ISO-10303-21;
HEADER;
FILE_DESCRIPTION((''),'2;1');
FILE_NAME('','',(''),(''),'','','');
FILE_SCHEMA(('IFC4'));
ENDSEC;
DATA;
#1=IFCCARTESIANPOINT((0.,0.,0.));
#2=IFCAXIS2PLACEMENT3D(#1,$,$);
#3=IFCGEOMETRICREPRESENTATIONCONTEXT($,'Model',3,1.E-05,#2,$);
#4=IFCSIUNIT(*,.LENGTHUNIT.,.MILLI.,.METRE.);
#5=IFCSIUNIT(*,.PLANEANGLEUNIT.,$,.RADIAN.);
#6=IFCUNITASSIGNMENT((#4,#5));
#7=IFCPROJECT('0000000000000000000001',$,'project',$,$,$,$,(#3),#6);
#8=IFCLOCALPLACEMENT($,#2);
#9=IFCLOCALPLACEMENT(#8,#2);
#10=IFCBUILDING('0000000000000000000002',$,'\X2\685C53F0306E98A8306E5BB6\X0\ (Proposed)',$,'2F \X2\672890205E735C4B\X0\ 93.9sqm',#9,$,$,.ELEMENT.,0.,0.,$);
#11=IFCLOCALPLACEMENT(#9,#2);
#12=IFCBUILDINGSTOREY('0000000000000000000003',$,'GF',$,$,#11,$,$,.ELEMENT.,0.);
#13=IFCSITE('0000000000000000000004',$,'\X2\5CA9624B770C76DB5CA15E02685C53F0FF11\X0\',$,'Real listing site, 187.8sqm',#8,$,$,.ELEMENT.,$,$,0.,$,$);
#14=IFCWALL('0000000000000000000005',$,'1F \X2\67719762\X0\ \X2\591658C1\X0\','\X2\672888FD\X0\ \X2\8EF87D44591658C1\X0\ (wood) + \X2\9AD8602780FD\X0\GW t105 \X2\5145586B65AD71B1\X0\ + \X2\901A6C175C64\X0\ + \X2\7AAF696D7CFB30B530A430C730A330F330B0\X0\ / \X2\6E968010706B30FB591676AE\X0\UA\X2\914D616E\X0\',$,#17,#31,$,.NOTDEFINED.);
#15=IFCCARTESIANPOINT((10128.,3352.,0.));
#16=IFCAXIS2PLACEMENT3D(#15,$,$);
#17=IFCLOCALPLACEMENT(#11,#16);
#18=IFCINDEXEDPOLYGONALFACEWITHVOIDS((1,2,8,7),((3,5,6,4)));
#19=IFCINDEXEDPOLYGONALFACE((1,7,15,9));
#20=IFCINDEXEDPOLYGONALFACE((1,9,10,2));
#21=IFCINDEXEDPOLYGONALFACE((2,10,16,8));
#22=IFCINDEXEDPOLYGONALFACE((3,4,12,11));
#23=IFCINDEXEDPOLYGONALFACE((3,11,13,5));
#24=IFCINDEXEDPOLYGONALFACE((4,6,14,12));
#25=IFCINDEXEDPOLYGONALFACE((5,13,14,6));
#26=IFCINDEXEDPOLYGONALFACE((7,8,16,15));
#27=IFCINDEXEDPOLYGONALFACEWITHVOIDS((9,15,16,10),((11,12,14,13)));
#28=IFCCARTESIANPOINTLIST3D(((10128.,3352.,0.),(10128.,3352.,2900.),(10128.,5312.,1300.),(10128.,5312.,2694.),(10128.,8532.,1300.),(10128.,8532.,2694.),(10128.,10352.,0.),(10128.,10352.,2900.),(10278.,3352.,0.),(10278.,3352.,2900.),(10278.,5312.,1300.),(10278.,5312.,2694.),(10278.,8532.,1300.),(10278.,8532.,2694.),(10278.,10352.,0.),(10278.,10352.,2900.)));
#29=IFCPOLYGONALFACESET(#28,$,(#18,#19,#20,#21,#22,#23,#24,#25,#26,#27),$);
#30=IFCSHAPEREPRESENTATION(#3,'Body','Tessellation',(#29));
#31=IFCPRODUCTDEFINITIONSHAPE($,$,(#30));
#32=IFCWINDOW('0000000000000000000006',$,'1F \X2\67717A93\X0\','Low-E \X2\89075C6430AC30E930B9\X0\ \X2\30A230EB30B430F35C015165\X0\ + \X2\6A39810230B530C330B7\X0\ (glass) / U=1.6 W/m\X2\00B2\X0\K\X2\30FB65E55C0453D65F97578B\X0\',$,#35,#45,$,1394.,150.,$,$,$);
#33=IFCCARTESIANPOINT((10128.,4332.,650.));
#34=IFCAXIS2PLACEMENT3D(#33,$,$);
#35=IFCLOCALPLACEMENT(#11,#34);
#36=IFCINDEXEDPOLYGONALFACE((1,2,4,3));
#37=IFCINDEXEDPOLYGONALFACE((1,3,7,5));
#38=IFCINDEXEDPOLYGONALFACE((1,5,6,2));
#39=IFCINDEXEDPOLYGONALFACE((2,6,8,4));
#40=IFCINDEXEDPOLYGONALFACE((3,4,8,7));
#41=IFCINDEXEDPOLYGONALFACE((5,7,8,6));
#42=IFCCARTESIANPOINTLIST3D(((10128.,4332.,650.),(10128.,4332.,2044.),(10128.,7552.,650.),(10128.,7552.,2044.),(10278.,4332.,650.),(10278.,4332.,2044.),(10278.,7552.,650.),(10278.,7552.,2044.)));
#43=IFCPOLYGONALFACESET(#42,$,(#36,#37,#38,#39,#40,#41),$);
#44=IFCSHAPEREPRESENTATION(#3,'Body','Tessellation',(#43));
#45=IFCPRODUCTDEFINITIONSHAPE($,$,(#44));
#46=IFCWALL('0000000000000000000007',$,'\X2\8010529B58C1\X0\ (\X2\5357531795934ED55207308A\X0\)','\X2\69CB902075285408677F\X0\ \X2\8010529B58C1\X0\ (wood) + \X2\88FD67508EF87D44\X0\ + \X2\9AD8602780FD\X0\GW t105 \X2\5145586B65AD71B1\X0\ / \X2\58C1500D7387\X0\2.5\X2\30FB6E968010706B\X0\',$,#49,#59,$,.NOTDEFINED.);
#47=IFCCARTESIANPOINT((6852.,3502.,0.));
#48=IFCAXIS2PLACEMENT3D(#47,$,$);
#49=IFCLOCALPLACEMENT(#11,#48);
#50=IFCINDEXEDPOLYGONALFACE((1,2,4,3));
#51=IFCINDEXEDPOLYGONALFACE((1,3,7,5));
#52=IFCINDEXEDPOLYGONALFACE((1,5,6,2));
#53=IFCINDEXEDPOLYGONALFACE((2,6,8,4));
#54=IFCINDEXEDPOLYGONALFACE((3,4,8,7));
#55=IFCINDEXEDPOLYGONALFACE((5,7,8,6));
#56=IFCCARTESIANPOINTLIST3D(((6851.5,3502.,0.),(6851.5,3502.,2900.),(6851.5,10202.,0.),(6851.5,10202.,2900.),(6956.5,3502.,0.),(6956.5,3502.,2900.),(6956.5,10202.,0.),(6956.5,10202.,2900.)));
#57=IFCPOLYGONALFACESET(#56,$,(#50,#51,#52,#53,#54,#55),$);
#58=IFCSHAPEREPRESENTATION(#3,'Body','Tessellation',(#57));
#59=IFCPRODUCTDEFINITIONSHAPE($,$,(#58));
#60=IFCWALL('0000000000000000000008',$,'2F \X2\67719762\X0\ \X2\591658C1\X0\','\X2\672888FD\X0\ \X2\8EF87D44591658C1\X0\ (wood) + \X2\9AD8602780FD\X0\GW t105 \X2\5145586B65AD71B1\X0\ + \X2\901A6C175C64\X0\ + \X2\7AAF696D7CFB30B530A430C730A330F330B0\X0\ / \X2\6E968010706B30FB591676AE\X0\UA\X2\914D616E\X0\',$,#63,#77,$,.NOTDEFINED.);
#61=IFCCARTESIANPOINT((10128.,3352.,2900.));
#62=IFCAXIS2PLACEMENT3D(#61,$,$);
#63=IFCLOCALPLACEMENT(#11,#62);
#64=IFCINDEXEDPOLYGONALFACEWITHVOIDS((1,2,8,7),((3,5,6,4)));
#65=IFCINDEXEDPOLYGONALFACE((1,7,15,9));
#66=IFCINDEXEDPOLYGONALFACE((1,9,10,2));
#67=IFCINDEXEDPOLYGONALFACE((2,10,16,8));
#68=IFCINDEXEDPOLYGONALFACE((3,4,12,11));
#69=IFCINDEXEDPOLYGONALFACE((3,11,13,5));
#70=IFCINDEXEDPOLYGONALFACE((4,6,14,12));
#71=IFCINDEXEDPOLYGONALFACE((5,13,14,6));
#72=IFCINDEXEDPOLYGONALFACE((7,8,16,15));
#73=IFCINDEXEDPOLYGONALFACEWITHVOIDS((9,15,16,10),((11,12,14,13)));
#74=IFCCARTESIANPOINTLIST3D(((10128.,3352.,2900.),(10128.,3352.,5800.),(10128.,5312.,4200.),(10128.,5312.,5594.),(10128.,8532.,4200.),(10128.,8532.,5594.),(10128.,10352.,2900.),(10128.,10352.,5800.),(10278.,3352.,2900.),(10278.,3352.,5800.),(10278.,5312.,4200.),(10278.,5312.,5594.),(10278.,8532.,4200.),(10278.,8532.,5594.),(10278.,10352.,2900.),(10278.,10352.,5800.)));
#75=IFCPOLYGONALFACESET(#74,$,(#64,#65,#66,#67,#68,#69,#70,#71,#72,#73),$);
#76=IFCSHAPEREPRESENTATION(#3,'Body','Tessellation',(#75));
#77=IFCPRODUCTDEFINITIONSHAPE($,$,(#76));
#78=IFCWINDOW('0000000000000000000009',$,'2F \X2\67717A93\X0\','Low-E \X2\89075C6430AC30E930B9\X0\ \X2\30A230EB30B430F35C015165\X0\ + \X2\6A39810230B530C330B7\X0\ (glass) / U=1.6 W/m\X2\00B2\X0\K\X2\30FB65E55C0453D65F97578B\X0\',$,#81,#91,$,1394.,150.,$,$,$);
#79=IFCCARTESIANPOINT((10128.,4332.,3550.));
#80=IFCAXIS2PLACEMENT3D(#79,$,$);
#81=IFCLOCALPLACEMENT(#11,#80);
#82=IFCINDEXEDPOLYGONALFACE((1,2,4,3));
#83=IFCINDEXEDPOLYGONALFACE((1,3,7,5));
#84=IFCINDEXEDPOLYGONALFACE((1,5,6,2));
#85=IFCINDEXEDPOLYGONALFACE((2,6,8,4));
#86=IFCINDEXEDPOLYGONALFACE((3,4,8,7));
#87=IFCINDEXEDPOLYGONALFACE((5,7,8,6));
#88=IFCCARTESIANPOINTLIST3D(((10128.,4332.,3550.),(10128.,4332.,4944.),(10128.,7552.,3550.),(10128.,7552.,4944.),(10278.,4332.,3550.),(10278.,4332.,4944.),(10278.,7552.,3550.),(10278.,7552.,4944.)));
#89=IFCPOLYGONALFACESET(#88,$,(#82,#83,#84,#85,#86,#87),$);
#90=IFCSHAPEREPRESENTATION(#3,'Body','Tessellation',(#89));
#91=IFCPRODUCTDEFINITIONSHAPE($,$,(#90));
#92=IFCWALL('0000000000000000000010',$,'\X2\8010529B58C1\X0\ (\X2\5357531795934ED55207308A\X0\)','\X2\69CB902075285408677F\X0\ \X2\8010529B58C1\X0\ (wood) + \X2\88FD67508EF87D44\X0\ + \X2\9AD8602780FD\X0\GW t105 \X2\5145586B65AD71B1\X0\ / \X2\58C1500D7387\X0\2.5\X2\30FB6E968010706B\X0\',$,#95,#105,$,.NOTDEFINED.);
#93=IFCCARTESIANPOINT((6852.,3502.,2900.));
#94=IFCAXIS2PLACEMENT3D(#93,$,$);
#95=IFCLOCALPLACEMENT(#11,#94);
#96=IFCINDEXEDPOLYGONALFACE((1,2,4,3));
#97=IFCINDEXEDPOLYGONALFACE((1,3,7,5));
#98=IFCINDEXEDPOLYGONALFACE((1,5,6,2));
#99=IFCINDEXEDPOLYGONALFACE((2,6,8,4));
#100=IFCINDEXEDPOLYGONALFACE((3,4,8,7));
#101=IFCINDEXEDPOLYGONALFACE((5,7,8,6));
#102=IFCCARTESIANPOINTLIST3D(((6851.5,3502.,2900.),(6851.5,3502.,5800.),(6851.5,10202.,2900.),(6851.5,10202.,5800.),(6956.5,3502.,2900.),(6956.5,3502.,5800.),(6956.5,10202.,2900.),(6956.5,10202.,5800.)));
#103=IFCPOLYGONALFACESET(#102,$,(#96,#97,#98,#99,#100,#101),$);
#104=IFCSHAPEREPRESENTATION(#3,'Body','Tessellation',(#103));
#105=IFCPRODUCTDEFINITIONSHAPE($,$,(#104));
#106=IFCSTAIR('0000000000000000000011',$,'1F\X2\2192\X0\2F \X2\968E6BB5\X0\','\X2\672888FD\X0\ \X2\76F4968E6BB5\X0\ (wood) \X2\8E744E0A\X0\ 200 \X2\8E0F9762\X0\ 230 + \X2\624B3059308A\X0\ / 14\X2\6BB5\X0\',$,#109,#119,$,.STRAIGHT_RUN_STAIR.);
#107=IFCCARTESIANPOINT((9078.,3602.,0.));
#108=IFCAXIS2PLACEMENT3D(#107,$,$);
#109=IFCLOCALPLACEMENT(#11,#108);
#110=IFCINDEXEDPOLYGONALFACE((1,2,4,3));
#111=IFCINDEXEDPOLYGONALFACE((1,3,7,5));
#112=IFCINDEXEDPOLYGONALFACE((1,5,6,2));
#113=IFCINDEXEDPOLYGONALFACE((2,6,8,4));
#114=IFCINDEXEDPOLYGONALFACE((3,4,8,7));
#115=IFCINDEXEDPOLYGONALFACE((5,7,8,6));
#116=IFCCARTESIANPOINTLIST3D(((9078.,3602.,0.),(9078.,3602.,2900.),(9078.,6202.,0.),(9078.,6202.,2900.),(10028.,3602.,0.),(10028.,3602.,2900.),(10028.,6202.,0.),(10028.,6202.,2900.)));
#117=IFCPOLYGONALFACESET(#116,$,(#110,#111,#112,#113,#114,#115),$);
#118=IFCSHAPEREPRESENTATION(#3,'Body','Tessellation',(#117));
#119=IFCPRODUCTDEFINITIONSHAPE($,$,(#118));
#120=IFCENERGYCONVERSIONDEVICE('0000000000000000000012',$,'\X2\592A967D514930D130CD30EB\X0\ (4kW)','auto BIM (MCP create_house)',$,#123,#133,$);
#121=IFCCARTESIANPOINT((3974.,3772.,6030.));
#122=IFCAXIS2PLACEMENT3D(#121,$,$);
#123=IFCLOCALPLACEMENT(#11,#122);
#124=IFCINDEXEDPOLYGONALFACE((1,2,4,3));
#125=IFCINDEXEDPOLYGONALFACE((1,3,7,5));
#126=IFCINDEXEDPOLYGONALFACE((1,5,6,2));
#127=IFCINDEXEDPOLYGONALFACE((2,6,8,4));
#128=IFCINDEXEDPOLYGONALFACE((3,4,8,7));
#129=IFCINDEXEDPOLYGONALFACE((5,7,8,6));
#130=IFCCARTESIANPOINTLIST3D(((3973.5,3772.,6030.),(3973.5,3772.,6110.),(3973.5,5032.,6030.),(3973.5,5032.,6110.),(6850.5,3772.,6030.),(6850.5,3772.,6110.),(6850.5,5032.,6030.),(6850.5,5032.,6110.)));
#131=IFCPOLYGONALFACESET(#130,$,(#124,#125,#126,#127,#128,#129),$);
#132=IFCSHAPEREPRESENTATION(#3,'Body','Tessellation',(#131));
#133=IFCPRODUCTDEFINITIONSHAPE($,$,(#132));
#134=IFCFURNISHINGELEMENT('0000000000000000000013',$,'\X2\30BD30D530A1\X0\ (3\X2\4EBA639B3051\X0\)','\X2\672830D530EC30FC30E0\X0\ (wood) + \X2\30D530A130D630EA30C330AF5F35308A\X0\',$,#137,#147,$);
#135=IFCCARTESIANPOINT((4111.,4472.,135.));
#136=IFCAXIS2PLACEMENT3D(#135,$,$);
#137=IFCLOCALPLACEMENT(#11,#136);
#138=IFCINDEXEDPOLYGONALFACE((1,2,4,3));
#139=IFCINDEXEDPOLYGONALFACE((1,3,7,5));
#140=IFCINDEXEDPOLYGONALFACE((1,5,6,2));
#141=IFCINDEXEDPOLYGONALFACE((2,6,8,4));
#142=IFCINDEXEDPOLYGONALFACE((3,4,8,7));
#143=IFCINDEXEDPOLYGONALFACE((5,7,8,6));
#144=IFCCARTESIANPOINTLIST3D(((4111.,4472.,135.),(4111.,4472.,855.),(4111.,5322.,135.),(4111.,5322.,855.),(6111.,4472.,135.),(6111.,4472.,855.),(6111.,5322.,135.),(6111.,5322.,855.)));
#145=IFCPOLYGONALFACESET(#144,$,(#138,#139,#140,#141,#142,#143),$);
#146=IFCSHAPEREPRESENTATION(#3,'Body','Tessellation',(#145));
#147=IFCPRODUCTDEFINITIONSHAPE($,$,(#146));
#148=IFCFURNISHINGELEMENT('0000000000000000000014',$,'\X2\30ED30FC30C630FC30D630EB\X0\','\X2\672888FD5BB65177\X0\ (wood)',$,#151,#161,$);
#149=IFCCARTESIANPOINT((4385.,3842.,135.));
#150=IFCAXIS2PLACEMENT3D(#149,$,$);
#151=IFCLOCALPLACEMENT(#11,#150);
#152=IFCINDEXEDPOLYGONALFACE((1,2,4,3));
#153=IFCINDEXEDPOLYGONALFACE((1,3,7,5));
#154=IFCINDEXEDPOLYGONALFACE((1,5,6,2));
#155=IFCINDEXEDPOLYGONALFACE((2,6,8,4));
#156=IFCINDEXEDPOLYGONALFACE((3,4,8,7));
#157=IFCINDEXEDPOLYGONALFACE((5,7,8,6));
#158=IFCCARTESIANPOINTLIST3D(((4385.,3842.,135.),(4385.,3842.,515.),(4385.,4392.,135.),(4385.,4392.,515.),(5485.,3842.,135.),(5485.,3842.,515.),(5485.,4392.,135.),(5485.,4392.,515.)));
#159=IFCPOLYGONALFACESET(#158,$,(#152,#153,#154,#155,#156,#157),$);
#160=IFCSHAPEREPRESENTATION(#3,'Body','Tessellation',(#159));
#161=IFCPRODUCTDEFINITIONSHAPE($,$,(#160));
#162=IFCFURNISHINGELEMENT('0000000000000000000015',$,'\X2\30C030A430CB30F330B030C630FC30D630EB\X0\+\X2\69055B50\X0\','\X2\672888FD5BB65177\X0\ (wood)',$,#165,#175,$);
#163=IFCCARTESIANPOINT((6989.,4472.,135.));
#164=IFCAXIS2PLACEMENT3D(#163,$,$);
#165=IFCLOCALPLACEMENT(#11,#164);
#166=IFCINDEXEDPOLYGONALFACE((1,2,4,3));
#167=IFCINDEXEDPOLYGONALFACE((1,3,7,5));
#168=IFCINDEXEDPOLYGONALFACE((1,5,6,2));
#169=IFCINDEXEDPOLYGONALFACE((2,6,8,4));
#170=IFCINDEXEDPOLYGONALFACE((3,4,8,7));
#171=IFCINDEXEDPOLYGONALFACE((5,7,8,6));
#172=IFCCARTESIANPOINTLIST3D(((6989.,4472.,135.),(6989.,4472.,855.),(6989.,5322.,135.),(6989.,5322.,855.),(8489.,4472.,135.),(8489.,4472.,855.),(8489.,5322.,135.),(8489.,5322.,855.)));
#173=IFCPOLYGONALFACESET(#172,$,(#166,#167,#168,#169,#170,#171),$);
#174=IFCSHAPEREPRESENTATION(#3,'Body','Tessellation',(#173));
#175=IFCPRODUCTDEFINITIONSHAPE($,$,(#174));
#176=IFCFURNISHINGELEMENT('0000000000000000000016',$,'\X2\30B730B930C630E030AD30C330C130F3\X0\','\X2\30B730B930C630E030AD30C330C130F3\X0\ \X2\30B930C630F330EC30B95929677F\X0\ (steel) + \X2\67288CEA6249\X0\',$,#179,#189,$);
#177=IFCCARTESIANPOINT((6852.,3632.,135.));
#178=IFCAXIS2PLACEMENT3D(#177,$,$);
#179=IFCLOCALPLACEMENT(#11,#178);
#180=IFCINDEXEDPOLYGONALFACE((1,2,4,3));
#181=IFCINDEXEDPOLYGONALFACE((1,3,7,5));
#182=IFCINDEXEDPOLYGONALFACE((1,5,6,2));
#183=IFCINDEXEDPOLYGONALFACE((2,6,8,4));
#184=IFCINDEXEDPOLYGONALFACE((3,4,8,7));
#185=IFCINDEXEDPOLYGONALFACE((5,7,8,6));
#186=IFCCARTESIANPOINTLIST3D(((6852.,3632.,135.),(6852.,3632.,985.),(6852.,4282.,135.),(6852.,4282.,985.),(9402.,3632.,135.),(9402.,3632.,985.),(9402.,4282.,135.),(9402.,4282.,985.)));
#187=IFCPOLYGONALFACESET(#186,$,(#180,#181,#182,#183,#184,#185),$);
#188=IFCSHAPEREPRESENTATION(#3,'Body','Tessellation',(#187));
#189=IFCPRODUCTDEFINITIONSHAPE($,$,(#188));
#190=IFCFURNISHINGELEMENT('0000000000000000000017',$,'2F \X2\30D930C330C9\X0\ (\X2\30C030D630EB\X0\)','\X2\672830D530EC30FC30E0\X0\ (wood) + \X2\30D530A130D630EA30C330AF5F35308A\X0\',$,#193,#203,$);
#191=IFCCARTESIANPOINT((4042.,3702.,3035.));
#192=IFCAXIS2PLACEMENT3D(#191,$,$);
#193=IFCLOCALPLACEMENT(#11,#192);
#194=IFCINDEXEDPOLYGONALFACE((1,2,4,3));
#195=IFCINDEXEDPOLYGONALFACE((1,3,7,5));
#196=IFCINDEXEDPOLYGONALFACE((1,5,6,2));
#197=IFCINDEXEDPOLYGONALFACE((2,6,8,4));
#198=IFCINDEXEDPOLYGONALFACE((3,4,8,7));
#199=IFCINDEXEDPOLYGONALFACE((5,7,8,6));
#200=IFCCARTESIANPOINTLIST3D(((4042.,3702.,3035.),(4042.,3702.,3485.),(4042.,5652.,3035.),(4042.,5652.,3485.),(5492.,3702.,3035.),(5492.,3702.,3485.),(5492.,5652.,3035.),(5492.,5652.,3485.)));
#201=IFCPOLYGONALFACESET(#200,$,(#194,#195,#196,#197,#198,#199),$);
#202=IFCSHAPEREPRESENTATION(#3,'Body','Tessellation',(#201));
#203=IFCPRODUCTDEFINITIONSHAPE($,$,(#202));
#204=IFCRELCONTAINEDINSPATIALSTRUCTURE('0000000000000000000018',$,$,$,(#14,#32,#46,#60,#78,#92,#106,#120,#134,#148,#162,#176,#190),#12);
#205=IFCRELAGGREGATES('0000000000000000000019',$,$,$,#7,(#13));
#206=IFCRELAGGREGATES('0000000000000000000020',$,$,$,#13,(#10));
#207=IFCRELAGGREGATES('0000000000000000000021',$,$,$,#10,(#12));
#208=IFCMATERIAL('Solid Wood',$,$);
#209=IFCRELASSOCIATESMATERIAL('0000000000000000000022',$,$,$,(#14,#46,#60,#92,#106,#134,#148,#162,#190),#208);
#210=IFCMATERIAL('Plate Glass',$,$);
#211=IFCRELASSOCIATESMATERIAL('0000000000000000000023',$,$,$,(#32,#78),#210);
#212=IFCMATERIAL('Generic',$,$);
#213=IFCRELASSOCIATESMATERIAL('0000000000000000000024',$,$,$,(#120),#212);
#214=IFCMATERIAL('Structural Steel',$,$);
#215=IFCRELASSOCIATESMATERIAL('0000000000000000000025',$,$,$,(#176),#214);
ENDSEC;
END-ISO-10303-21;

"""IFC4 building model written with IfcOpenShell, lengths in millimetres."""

from ifc_helpers import new_model, si_unit, frame, frame_2d, origin, place, context, project, spatial, rectangle, extrude, material, element, fill, save


model = new_model("IFC4")

# Units and contexts
model_context = context("Model", 3, precision=1e-05, world=origin())
ifc_project = project(units=[si_unit("LENGTHUNIT", "METRE", prefix="MILLI"), si_unit("PLANEANGLEUNIT", "RADIAN")], contexts=[model_context])

# Site, building, storey
site_placement = place(None, origin())
site = spatial("IfcSite", under=ifc_project, at=site_placement, Name="岩手県盛岡市桜台１", ObjectType="Real listing site, 187.8sqm", CompositionType="ELEMENT", RefElevation=0.0)
building_placement = place(site_placement, origin())
building = spatial("IfcBuilding", under=site, at=building_placement, Name="桜台の風の家 (Proposed)", ObjectType="2F 木造平屋 93.9sqm", CompositionType="ELEMENT", ElevationOfRefHeight=0.0, ElevationOfTerrain=0.0)
storey_placement = place(building_placement, origin())
storey = spatial("IfcBuildingStorey", under=building, at=storey_placement, Name="GF", CompositionType="ELEMENT", Elevation=0.0)

# Wall, opening, window
ifc_material_1 = material(Name="Solid Wood")
wall_1_placement = place(storey_placement, frame((10128.0, 3352.0, 0.0)))
wall_1 = element("IfcWall", 1, at=wall_1_placement, inside=storey, material=ifc_material_1, Name="1F 東面 外壁", Description="木製 軸組外壁 (wood) + 高性能GW t105 充填断熱 + 通気層 + 窯業系サイディング / 準耐火・外皮UA配慮", PredefinedType="NOTDEFINED", context=model_context, shape_type="SweptSolid", body=[
    extrude(rectangle(XDim=150.0, YDim=7000.0, at=frame_2d((75.0, 3500.0))), frame((10128.0, 3352.0, 0.0)), (0.0, 0.0, 1.0), 2900.0),
])
opening_1_placement = place(storey_placement, frame((10128.0, 4332.0, 650.0)))
opening_1 = element("IfcOpeningElement", 2, at=opening_1_placement, cuts=wall_1, PredefinedType="NOTDEFINED", context=model_context, shape_type="SweptSolid", body=[
    extrude(rectangle(XDim=150.0, YDim=3220.0, at=frame_2d((75.0, 1610.0))), frame((10128.0, 4332.0, 650.0)), (0.0, 0.0, 1.0), 1394.0),
])
ifc_material_2 = material(Name="Plate Glass")
window_1_placement = place(storey_placement, frame((10128.0, 4332.0, 650.0)))
window_1 = element("IfcWindow", 3, at=window_1_placement, inside=storey, material=ifc_material_2, Name="1F 東窓", Description="Low-E 複層ガラス アルゴン封入 + 樹脂サッシ (glass) / U=1.6 W/m²K・日射取得型", OverallHeight=1394.0, OverallWidth=150.0, context=model_context, shape_type="SweptSolid", body=[
    extrude(rectangle(XDim=150.0, YDim=3220.0, at=frame_2d((75.0, 1610.0))), frame((10128.0, 4332.0, 650.0)), (0.0, 0.0, 1.0), 1394.0),
])
fill(opening_1, window_1)

# Wall
wall_2_placement = place(storey_placement, frame((6852.0, 3502.0, 0.0)))
element("IfcWall", 4, at=wall_2_placement, inside=storey, material=ifc_material_1, Name="耐力壁 (南北間仕切り)", Description="構造用合板 耐力壁 (wood) + 製材軸組 + 高性能GW t105 充填断熱 / 壁倍率2.5・準耐火", PredefinedType="NOTDEFINED", context=model_context, shape_type="SweptSolid", body=[
    extrude(rectangle(XDim=105.0, YDim=6700.0, at=frame_2d((52.0, 3350.0))), frame((6852.0, 3502.0, 0.0)), (0.0, 0.0, 1.0), 2900.0),
])

# Wall, opening, window
wall_3_placement = place(storey_placement, frame((10128.0, 3352.0, 2900.0)))
wall_3 = element("IfcWall", 5, at=wall_3_placement, inside=storey, material=ifc_material_1, Name="2F 東面 外壁", Description="木製 軸組外壁 (wood) + 高性能GW t105 充填断熱 + 通気層 + 窯業系サイディング / 準耐火・外皮UA配慮", PredefinedType="NOTDEFINED", context=model_context, shape_type="SweptSolid", body=[
    extrude(rectangle(XDim=150.0, YDim=7000.0, at=frame_2d((75.0, 3500.0))), frame((10128.0, 3352.0, 2900.0)), (0.0, 0.0, 1.0), 2900.0),
])
opening_2_placement = place(storey_placement, frame((10128.0, 4332.0, 3550.0)))
opening_2 = element("IfcOpeningElement", 6, at=opening_2_placement, cuts=wall_3, PredefinedType="NOTDEFINED", context=model_context, shape_type="SweptSolid", body=[
    extrude(rectangle(XDim=150.0, YDim=3220.0, at=frame_2d((75.0, 1610.0))), frame((10128.0, 4332.0, 3550.0)), (0.0, 0.0, 1.0), 1394.0),
])
window_2_placement = place(storey_placement, frame((10128.0, 4332.0, 3550.0)))
window_2 = element("IfcWindow", 7, at=window_2_placement, inside=storey, material=ifc_material_2, Name="2F 東窓", Description="Low-E 複層ガラス アルゴン封入 + 樹脂サッシ (glass) / U=1.6 W/m²K・日射取得型", OverallHeight=1394.0, OverallWidth=150.0, context=model_context, shape_type="SweptSolid", body=[
    extrude(rectangle(XDim=150.0, YDim=3220.0, at=frame_2d((75.0, 1610.0))), frame((10128.0, 4332.0, 3550.0)), (0.0, 0.0, 1.0), 1394.0),
])
fill(opening_2, window_2)

# Wall
wall_4_placement = place(storey_placement, frame((6852.0, 3502.0, 2900.0)))
element("IfcWall", 8, at=wall_4_placement, inside=storey, material=ifc_material_1, Name="耐力壁 (南北間仕切り)", Description="構造用合板 耐力壁 (wood) + 製材軸組 + 高性能GW t105 充填断熱 / 壁倍率2.5・準耐火", PredefinedType="NOTDEFINED", context=model_context, shape_type="SweptSolid", body=[
    extrude(rectangle(XDim=105.0, YDim=6700.0, at=frame_2d((52.0, 3350.0))), frame((6852.0, 3502.0, 2900.0)), (0.0, 0.0, 1.0), 2900.0),
])

# Stair
stair_placement = place(storey_placement, frame((9078.0, 3602.0, 0.0)))
element("IfcStair", 9, at=stair_placement, inside=storey, material=ifc_material_1, Name="1F→2F 階段", Description="木製 直階段 (wood) 蹴上 200 踏面 230 + 手すり / 14段", PredefinedType="STRAIGHT_RUN_STAIR", context=model_context, shape_type="SweptSolid", body=[
    extrude(rectangle(XDim=950.0, YDim=2600.0, at=frame_2d((475.0, 1300.0))), frame((9078.0, 3602.0, 0.0)), (0.0, 0.0, 1.0), 2900.0),
])

# Energy conversion device
ifc_material_3 = material(Name="Generic")
energy_conversion_device_placement = place(storey_placement, frame((3974.0, 3772.0, 6030.0)))
element("IfcEnergyConversionDevice", 10, at=energy_conversion_device_placement, inside=storey, material=ifc_material_3, Name="太陽光パネル (4kW)", Description="auto BIM (MCP create_house)", context=model_context, shape_type="SweptSolid", body=[
    extrude(rectangle(XDim=2877.0, YDim=1260.0, at=frame_2d((1438.0, 630.0))), frame((3974.0, 3772.0, 6030.0)), (0.0, 0.0, 1.0), 80.0),
])

# Furnishing elements
furnishing_1_placement = place(storey_placement, frame((4111.0, 4472.0, 135.0)))
element("IfcFurnishingElement", 11, at=furnishing_1_placement, inside=storey, material=ifc_material_1, Name="ソファ (3人掛け)", Description="木フレーム (wood) + ファブリック張り", context=model_context, shape_type="SweptSolid", body=[
    extrude(rectangle(XDim=2000.0, YDim=850.0, at=frame_2d((1000.0, 425.0))), frame((4111.0, 4472.0, 135.0)), (0.0, 0.0, 1.0), 720.0),
])
furnishing_2_placement = place(storey_placement, frame((4385.0, 3842.0, 135.0)))
element("IfcFurnishingElement", 12, at=furnishing_2_placement, inside=storey, material=ifc_material_1, Name="ローテーブル", Description="木製家具 (wood)", context=model_context, shape_type="SweptSolid", body=[
    extrude(rectangle(XDim=1100.0, YDim=550.0, at=frame_2d((550.0, 275.0))), frame((4385.0, 3842.0, 135.0)), (0.0, 0.0, 1.0), 380.0),
])
furnishing_3_placement = place(storey_placement, frame((6989.0, 4472.0, 135.0)))
element("IfcFurnishingElement", 13, at=furnishing_3_placement, inside=storey, material=ifc_material_1, Name="ダイニングテーブル+椅子", Description="木製家具 (wood)", context=model_context, shape_type="SweptSolid", body=[
    extrude(rectangle(XDim=1500.0, YDim=850.0, at=frame_2d((750.0, 425.0))), frame((6989.0, 4472.0, 135.0)), (0.0, 0.0, 1.0), 720.0),
])
ifc_material_4 = material(Name="Structural Steel")
furnishing_4_placement = place(storey_placement, frame((6852.0, 3632.0, 135.0)))
element("IfcFurnishingElement", 14, at=furnishing_4_placement, inside=storey, material=ifc_material_4, Name="システムキッチン", Description="システムキッチン ステンレス天板 (steel) + 木質扉", context=model_context, shape_type="SweptSolid", body=[
    extrude(rectangle(XDim=2550.0, YDim=650.0, at=frame_2d((1275.0, 325.0))), frame((6852.0, 3632.0, 135.0)), (0.0, 0.0, 1.0), 850.0),
])
furnishing_5_placement = place(storey_placement, frame((4042.0, 3702.0, 3035.0)))
element("IfcFurnishingElement", 15, at=furnishing_5_placement, inside=storey, material=ifc_material_1, Name="2F ベッド (ダブル)", Description="木フレーム (wood) + ファブリック張り", context=model_context, shape_type="SweptSolid", body=[
    extrude(rectangle(XDim=1450.0, YDim=1950.0, at=frame_2d((725.0, 975.0))), frame((4042.0, 3702.0, 3035.0)), (0.0, 0.0, 1.0), 450.0),
])

save(model, "model.ifc")
